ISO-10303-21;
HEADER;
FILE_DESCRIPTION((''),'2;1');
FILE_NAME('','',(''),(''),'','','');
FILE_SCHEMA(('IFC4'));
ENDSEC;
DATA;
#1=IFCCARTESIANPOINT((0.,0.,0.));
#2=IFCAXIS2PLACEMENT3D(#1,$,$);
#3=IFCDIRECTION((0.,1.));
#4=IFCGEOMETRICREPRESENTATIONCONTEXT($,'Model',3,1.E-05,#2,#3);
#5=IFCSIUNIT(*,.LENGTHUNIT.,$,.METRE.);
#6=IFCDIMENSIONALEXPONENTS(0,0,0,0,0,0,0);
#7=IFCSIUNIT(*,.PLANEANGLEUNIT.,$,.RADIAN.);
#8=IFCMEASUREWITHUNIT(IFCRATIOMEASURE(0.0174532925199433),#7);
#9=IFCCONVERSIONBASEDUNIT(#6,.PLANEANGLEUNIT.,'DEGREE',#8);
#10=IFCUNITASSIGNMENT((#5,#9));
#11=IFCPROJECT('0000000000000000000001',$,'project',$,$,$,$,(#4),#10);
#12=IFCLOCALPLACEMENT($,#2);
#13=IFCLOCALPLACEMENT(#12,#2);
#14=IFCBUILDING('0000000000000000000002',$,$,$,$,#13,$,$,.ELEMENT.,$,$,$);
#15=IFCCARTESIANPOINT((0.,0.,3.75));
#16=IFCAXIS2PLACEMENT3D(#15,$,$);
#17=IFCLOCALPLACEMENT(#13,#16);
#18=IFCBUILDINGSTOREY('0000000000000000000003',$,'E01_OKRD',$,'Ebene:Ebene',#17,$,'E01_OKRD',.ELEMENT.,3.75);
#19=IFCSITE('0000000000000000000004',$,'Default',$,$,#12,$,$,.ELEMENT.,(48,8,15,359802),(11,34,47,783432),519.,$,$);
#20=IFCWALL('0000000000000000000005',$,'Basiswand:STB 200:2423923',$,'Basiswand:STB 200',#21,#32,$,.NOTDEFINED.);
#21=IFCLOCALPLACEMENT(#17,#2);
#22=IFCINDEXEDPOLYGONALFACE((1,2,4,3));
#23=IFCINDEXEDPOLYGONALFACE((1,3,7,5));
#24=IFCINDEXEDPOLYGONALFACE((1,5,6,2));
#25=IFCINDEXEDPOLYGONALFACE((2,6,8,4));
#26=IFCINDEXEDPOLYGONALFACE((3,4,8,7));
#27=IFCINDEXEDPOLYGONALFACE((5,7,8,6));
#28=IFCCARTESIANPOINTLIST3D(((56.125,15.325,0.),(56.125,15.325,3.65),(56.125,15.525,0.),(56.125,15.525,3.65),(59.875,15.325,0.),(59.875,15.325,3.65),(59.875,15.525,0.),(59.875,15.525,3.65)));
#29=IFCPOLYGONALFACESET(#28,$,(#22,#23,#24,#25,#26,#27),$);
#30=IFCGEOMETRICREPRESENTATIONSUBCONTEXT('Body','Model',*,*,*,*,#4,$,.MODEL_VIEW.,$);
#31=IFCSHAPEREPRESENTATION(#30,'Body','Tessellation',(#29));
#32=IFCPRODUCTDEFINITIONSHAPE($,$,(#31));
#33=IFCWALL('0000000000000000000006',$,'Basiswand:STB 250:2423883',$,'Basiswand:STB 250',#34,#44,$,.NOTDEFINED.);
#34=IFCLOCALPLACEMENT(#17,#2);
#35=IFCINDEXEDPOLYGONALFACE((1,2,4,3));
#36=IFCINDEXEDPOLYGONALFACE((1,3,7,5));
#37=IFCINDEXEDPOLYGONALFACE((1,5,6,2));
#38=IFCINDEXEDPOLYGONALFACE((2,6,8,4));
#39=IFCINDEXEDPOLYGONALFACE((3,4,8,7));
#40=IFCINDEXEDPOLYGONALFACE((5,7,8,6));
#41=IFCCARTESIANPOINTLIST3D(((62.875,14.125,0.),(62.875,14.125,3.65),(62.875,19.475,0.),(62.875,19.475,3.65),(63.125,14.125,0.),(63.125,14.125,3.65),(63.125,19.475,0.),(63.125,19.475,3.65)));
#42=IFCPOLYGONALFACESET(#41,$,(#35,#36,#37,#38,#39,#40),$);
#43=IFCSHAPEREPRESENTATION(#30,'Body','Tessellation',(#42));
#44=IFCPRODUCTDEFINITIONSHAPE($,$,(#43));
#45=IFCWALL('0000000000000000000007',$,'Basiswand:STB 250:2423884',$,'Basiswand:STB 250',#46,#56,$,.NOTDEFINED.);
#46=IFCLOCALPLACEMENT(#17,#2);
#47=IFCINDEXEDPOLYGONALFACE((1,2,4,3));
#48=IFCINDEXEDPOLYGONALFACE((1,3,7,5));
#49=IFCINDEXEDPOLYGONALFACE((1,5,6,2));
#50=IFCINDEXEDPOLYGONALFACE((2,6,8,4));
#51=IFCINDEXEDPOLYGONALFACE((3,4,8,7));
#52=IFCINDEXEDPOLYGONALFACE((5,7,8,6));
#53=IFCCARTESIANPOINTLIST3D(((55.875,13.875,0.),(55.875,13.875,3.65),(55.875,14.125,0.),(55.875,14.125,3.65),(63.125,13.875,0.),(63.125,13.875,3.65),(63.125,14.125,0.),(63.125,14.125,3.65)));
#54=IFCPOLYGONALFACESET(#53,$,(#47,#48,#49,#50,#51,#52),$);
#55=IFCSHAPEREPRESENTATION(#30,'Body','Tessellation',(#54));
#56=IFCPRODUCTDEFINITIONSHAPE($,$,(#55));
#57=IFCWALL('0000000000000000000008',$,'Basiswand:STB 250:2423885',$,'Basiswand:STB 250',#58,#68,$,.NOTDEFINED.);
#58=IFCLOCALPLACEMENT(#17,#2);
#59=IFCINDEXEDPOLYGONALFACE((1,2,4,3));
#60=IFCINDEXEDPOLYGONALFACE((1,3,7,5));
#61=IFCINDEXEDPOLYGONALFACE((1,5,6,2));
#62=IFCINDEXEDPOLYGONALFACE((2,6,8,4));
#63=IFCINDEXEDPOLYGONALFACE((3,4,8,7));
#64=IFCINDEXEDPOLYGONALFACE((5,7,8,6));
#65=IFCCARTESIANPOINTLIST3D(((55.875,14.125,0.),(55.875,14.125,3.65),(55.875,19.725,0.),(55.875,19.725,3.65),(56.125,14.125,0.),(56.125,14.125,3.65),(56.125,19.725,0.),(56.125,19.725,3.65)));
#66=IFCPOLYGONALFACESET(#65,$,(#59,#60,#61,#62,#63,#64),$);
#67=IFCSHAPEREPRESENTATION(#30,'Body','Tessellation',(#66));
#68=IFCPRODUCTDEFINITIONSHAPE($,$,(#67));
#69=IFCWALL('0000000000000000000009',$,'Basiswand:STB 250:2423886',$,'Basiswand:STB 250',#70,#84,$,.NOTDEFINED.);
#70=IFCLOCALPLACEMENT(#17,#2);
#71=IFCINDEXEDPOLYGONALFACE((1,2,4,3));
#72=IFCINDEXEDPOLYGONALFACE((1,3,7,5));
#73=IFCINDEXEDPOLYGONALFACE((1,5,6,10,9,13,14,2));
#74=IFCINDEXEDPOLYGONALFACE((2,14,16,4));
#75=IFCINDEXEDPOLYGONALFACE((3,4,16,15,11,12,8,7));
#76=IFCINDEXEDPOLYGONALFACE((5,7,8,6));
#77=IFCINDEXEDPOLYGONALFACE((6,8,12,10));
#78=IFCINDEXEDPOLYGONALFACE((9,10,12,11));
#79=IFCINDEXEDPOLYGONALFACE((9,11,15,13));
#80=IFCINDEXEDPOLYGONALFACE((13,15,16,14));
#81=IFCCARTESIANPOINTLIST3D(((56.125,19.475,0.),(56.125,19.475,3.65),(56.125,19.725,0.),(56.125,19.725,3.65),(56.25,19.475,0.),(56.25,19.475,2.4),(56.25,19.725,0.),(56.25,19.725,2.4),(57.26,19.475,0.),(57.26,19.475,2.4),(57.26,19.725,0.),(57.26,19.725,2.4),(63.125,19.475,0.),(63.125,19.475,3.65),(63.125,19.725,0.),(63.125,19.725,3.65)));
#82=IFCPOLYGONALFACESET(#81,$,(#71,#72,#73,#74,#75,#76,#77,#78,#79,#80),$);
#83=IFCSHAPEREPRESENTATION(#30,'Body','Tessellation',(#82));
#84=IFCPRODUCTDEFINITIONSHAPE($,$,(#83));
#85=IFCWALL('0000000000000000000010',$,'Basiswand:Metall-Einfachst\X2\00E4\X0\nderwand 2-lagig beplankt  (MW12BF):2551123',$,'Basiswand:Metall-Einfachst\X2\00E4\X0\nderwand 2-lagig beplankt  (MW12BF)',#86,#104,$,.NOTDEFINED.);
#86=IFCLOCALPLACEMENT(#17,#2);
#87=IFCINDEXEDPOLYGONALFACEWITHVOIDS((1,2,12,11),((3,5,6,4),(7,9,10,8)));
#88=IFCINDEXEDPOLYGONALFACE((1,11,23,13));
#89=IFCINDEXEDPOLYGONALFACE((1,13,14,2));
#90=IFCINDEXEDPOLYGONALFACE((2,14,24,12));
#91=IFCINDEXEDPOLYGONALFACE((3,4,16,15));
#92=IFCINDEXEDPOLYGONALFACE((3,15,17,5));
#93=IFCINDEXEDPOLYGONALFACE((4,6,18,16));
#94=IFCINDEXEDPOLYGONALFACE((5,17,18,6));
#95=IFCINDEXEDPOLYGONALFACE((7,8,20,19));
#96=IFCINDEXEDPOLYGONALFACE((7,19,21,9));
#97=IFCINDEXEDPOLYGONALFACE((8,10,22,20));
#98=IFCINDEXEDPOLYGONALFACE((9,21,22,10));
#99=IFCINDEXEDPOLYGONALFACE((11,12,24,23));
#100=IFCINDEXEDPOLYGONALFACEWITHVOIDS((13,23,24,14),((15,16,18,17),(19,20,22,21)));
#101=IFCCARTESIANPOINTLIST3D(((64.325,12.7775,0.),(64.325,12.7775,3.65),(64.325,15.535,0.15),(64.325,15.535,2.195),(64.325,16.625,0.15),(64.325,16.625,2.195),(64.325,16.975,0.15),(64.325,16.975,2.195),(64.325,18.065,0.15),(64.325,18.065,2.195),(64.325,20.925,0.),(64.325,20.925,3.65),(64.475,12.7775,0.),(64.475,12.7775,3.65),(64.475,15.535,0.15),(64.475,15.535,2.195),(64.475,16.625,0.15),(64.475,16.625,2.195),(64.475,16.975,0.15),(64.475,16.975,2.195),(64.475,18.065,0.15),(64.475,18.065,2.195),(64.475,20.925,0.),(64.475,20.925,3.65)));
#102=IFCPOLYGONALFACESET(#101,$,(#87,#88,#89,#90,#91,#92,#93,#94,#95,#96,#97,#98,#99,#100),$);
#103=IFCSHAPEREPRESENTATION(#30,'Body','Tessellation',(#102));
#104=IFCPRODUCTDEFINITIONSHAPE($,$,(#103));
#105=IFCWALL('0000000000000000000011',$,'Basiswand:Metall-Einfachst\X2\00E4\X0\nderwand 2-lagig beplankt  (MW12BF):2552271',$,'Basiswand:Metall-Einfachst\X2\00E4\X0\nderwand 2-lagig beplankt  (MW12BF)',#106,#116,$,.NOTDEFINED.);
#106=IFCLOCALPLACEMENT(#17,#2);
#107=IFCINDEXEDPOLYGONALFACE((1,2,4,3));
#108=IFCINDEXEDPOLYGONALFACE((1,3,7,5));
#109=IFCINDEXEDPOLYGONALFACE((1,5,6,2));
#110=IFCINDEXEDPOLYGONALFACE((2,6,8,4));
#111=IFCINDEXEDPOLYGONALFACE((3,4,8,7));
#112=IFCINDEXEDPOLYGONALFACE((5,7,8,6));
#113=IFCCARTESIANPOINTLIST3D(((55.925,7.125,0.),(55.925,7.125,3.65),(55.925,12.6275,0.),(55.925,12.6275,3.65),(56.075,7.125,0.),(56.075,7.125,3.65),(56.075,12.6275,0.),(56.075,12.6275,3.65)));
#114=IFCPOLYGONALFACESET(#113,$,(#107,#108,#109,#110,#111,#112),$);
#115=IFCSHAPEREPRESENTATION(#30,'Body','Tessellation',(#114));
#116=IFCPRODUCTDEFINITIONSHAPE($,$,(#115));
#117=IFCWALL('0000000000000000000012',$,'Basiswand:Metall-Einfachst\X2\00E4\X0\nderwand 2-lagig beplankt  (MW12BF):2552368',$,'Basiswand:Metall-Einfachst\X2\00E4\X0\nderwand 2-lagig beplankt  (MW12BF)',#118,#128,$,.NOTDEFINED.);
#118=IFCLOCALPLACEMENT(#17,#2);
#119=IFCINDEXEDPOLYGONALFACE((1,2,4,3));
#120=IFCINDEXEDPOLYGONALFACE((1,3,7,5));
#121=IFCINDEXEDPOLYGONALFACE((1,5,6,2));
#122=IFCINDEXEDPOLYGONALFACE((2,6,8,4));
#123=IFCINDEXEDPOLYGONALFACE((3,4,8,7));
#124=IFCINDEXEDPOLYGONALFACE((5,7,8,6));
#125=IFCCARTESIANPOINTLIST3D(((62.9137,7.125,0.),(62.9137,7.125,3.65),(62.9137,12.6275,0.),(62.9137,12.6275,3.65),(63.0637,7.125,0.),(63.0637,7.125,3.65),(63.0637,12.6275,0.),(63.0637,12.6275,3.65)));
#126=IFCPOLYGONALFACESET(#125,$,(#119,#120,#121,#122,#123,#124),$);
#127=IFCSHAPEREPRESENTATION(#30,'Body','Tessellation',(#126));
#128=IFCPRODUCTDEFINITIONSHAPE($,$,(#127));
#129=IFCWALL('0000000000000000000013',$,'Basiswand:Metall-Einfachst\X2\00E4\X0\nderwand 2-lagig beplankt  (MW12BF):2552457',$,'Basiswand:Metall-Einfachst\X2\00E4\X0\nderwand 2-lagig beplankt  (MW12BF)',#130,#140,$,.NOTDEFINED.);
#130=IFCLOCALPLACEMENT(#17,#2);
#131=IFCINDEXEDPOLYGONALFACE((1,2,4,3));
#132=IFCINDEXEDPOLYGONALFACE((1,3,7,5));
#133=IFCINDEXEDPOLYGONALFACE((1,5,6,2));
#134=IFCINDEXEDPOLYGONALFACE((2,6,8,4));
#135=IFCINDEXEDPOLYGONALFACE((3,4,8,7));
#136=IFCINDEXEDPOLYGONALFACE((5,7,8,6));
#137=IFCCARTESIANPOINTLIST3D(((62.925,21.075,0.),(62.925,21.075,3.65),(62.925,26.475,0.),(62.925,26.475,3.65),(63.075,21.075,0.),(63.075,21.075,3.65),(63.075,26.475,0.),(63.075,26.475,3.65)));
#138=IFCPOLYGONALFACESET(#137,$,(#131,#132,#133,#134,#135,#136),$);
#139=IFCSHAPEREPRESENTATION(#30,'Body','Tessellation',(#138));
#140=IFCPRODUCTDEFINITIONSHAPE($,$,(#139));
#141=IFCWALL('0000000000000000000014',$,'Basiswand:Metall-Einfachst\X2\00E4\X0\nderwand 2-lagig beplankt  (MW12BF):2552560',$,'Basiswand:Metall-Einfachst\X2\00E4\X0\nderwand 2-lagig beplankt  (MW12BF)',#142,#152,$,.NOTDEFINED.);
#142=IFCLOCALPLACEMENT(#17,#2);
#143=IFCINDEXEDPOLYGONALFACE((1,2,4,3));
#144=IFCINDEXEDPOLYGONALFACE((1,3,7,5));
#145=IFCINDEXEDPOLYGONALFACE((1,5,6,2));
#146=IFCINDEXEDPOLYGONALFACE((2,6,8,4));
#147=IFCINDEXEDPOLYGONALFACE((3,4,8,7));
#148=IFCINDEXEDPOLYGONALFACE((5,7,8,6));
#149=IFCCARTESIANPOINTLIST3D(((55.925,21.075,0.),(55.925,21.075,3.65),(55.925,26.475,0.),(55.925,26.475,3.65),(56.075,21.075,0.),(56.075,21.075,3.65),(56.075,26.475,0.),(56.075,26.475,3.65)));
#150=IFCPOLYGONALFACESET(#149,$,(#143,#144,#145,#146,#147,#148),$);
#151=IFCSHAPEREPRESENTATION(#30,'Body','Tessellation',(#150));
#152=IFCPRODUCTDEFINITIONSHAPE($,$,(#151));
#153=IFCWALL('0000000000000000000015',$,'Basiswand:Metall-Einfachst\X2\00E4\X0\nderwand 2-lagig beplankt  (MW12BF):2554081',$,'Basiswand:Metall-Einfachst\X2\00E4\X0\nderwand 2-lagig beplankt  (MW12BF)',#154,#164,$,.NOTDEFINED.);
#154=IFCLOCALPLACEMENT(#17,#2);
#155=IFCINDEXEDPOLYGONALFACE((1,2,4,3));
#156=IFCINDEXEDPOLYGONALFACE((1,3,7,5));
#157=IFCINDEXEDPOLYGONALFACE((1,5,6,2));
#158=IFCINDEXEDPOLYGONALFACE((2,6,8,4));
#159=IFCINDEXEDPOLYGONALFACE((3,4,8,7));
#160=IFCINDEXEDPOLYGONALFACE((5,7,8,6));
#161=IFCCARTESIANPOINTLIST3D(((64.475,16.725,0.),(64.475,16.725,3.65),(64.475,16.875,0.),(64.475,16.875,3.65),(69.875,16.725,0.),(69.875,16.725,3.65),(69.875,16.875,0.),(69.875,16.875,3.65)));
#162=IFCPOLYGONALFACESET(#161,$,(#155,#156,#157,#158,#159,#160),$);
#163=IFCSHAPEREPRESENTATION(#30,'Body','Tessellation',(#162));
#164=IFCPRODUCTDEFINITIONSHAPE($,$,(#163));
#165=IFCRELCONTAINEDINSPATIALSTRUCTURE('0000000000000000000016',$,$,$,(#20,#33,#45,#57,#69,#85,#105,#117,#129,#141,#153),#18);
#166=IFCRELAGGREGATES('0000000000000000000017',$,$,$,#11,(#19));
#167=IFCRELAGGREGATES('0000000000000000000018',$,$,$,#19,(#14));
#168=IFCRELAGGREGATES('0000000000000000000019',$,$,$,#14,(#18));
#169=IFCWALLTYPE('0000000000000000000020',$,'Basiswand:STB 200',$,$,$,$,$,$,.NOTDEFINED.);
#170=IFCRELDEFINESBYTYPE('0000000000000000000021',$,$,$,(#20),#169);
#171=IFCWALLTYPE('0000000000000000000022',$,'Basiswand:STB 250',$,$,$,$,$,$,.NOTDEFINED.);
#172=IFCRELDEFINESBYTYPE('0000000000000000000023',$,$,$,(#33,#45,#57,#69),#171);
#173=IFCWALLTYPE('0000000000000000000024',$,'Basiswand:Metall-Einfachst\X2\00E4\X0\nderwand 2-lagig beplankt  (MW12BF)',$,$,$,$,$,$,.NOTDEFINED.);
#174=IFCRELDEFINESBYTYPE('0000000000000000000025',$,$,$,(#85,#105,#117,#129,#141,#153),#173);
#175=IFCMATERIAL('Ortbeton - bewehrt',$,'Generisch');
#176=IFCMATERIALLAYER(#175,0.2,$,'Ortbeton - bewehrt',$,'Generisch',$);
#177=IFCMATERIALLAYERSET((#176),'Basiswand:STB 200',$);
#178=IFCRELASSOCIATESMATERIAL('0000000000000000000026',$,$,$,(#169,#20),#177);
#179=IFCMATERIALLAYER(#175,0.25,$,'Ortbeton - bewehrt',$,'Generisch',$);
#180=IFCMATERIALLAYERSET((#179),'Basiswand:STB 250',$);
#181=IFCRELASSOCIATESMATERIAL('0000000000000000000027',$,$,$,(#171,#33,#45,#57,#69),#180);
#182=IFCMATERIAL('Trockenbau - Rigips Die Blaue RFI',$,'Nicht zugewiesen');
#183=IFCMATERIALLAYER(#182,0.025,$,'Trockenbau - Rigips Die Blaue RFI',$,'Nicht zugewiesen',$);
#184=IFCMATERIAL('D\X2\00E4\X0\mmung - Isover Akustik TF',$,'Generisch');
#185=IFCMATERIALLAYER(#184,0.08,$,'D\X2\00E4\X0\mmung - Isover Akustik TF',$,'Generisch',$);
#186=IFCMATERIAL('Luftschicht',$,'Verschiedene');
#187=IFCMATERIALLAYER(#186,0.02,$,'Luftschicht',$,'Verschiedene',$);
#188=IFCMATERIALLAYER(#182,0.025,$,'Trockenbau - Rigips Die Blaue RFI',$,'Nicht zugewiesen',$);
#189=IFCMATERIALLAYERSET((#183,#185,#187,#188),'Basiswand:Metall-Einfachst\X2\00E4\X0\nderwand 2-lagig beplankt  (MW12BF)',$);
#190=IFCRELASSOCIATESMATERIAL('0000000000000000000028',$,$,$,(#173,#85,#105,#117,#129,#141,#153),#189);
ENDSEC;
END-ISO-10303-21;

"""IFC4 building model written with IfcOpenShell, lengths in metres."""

from ifc_helpers import new_model, entity, si_unit, converted_unit, direction, frame, frame_2d, origin, place, context, subcontext, project, spatial, rectangle, extrude, material, layer, layer_set, layer_usage, type_object, element, save


model = new_model("IFC4")

# Units and contexts
model_context = context("Model", 3, precision=1e-05, world=origin(), true_north=direction((0.0, 1.0)))
body_context = subcontext(model_context, "Body", "Model", "MODEL_VIEW")
ifc_project = project(units=[si_unit("LENGTHUNIT", "METRE"), converted_unit("PLANEANGLEUNIT", "DEGREE", entity("IfcRatioMeasure", 0.0174532925199433), si_unit("PLANEANGLEUNIT", "RADIAN"), dimensions=[0, 0, 0, 0, 0, 0, 0])], contexts=[model_context])

# Site, building, storey
site_placement = place(None, frame((0.0, 0.0, 0.0)))
site = spatial("IfcSite", under=ifc_project, at=site_placement, Name="Default", CompositionType="ELEMENT", RefLatitude=(48, 8, 15, 359802), RefLongitude=(11, 34, 47, 783432), RefElevation=519.0)
building_placement = place(site_placement, origin())
building = spatial("IfcBuilding", under=site, at=building_placement, CompositionType="ELEMENT")
storey_placement = place(building_placement, frame((0.0, 0.0, 3.75)))
storey = spatial("IfcBuildingStorey", under=building, at=storey_placement, Name="E01_OKRD", ObjectType="Ebene:Ebene", LongName="E01_OKRD", CompositionType="ELEMENT", Elevation=3.75)

# Shared definitions
ifc_material_1 = material(Name="Ortbeton - bewehrt", Category="Generisch")

# Shared definitions
ifc_layer_1 = layer(ifc_material_1, 0.2, Name="Ortbeton - bewehrt", Category="Generisch")
ifc_layer_set_1 = layer_set([ifc_layer_1], Name="Basiswand:STB 200")
wall_type_1 = type_object("IfcWallType", Name="Basiswand:STB 200", PredefinedType="NOTDEFINED", material=ifc_layer_set_1)

# Walls
ifc_layer_usage_1 = layer_usage(ifc_layer_set_1, "AXIS2", "POSITIVE", -0.1)
wall_1_placement = place(storey_placement, frame((56.125, 15.425, 0.0)))
element("IfcWall", 1, at=wall_1_placement, inside=storey, type_object=wall_type_1, material=ifc_layer_usage_1, Name="Basiswand:STB 200:2423923", ObjectType="Basiswand:STB 200", PredefinedType="NOTDEFINED", context=body_context, shape_type="SweptSolid", body=[
    extrude(rectangle(XDim=3.75, YDim=0.2, at=frame_2d((1.875, 0.0), x_axis=(-1.0, 0.0))), origin(), (0.0, 0.0, 1.0), 3.65),
])
ifc_layer_2 = layer(ifc_material_1, 0.25, Name="Ortbeton - bewehrt", Category="Generisch")
ifc_layer_set_2 = layer_set([ifc_layer_2], Name="Basiswand:STB 250")
ifc_layer_usage_2 = layer_usage(ifc_layer_set_2, "AXIS2", "NEGATIVE", 0.125)
wall_type_2 = type_object("IfcWallType", Name="Basiswand:STB 250", PredefinedType="NOTDEFINED", material=ifc_layer_set_2)
wall_2_placement = place(storey_placement, frame((63.0, 14.125, 0.0), z_axis=(0.0, 0.0, 1.0), x_axis=(0.0, 1.0, 0.0)))
element("IfcWall", 2, at=wall_2_placement, inside=storey, type_object=wall_type_2, material=ifc_layer_usage_2, Name="Basiswand:STB 250:2423883", ObjectType="Basiswand:STB 250", PredefinedType="NOTDEFINED", context=body_context, shape_type="SweptSolid", body=[
    extrude(rectangle(XDim=5.35, YDim=0.25, at=frame_2d((2.675, 0.0), x_axis=(-1.0, 0.0))), origin(), (0.0, 0.0, 1.0), 3.65),
])
ifc_layer_usage_3 = layer_usage(ifc_layer_set_2, "AXIS2", "NEGATIVE", 0.125)
wall_3_placement = place(storey_placement, frame((63.125, 14.0, 0.0), z_axis=(0.0, 0.0, 1.0), x_axis=(-1.0, 0.0, 0.0)))
element("IfcWall", 3, at=wall_3_placement, inside=storey, type_object=wall_type_2, material=ifc_layer_usage_3, Name="Basiswand:STB 250:2423884", ObjectType="Basiswand:STB 250", PredefinedType="NOTDEFINED", context=body_context, shape_type="SweptSolid", body=[
    extrude(rectangle(XDim=7.25, YDim=0.25, at=frame_2d((3.625, 0.0), x_axis=(-1.0, 0.0))), origin(), (0.0, 0.0, 1.0), 3.65),
])
ifc_layer_usage_4 = layer_usage(ifc_layer_set_2, "AXIS2", "NEGATIVE", 0.125)
wall_4_placement = place(storey_placement, frame((56.0, 14.125, 0.0), z_axis=(0.0, 0.0, 1.0), x_axis=(0.0, 1.0, 0.0)))
element("IfcWall", 4, at=wall_4_placement, inside=storey, type_object=wall_type_2, material=ifc_layer_usage_4, Name="Basiswand:STB 250:2423885", ObjectType="Basiswand:STB 250", PredefinedType="NOTDEFINED", context=body_context, shape_type="SweptSolid", body=[
    extrude(rectangle(XDim=5.6, YDim=0.25, at=frame_2d((2.8, 0.0), x_axis=(-1.0, 0.0))), origin(), (0.0, 0.0, 1.0), 3.65),
])

# Wall, opening
ifc_layer_usage_5 = layer_usage(ifc_layer_set_2, "AXIS2", "NEGATIVE", 0.125)
wall_5_placement = place(storey_placement, frame((56.125, 19.6, 0.0)))
wall_5 = element("IfcWall", 5, at=wall_5_placement, inside=storey, type_object=wall_type_2, material=ifc_layer_usage_5, Name="Basiswand:STB 250:2423886", ObjectType="Basiswand:STB 250", PredefinedType="NOTDEFINED", context=body_context, shape_type="SweptSolid", body=[
    extrude(rectangle(XDim=7.0, YDim=0.25, at=frame_2d((3.5, 0.0), x_axis=(-1.0, 0.0))), origin(), (0.0, 0.0, 1.0), 3.65),
])
opening_1_placement = place(wall_5_placement, frame((0.125, -0.125, 0.0)))
element("IfcOpeningElement", 6, at=opening_1_placement, cuts=wall_5, ObjectType="Opening", PredefinedType="OPENING", context=body_context, shape_type="SweptSolid", body=[
    extrude(rectangle(XDim=2.4, YDim=1.01, at=frame_2d((0.0, 0.0), x_axis=(0.0, 1.0))), frame((0.505, 0.0, 1.2), z_axis=(0.0, 1.0, 0.0), x_axis=(1.0, 0.0, 0.0)), (0.0, 0.0, 1.0), 0.25),
    extrude(rectangle(XDim=2.27, YDim=0.95, at=frame_2d((0.0, 0.0), x_axis=(1.0, 0.0))), frame((0.505, 0.295, 1.235), z_axis=(0.0, 1.0, 0.0), x_axis=(0.0, 0.0, -1.0)), (0.0, 0.0, 1.0), 0.255),
])

# Wall, openings
ifc_material_2 = material(Name="Trockenbau - Rigips Die Blaue RFI", Category="Nicht zugewiesen")
ifc_layer_3 = layer(ifc_material_2, 0.025, Name="Trockenbau - Rigips Die Blaue RFI", Category="Nicht zugewiesen")
ifc_material_3 = material(Name="Dämmung - Isover Akustik TF", Category="Generisch")
ifc_layer_4 = layer(ifc_material_3, 0.08, Name="Dämmung - Isover Akustik TF", Category="Generisch")
ifc_material_4 = material(Name="Luftschicht", Category="Verschiedene")
ifc_layer_5 = layer(ifc_material_4, 0.02, Name="Luftschicht", Category="Verschiedene")
ifc_layer_6 = layer(ifc_material_2, 0.025, Name="Trockenbau - Rigips Die Blaue RFI", Category="Nicht zugewiesen")
ifc_layer_set_3 = layer_set([ifc_layer_3, ifc_layer_4, ifc_layer_5, ifc_layer_6], Name="Basiswand:Metall-Einfachständerwand 2-lagig beplankt  (MW12BF)")
ifc_layer_usage_6 = layer_usage(ifc_layer_set_3, "AXIS2", "NEGATIVE", 0.075)
wall_type_3 = type_object("IfcWallType", Name="Basiswand:Metall-Einfachständerwand 2-lagig beplankt  (MW12BF)", PredefinedType="NOTDEFINED", material=ifc_layer_set_3)
wall_6_placement = place(storey_placement, frame((64.4, 20.925, 0.0), z_axis=(0.0, 0.0, 1.0), x_axis=(0.0, -1.0, 0.0)))
wall_6 = element("IfcWall", 7, at=wall_6_placement, inside=storey, type_object=wall_type_3, material=ifc_layer_usage_6, Name="Basiswand:Metall-Einfachständerwand 2-lagig beplankt  (MW12BF):2551123", ObjectType="Basiswand:Metall-Einfachständerwand 2-lagig beplankt  (MW12BF)", PredefinedType="NOTDEFINED", context=body_context, shape_type="SweptSolid", body=[
    extrude(rectangle(XDim=8.1475, YDim=0.15, at=frame_2d((4.0738, 0.0), x_axis=(-1.0, 0.0))), origin(), (0.0, 0.0, 1.0), 3.65),
])
opening_2_placement = place(wall_6_placement, frame((2.86, -0.075, 0.15)))
element("IfcOpeningElement", 8, at=opening_2_placement, cuts=wall_6, ObjectType="Opening", PredefinedType="OPENING", context=body_context, shape_type="SweptSolid", body=[
    extrude(rectangle(XDim=2.045, YDim=1.09, at=frame_2d((1.0225, 0.545), x_axis=(-1.0, 0.0))), frame((0.0, 0.0, 0.0), z_axis=(0.0, 1.0, 0.0), x_axis=(0.0, 0.0, 1.0)), (0.0, 0.0, 1.0), 0.15),
])
opening_3_placement = place(wall_6_placement, frame((4.3, -0.075, 0.15)))
element("IfcOpeningElement", 9, at=opening_3_placement, cuts=wall_6, ObjectType="Opening", PredefinedType="OPENING", context=body_context, shape_type="SweptSolid", body=[
    extrude(rectangle(XDim=2.045, YDim=1.09, at=frame_2d((1.0225, 0.545), x_axis=(-1.0, 0.0))), frame((0.0, 0.0, 0.0), z_axis=(0.0, 1.0, 0.0), x_axis=(0.0, 0.0, 1.0)), (0.0, 0.0, 1.0), 0.15),
])

# Walls
ifc_layer_usage_7 = layer_usage(ifc_layer_set_3, "AXIS2", "NEGATIVE", 0.075)
wall_7_placement = place(storey_placement, frame((56.0, 12.6275, 0.0), z_axis=(0.0, 0.0, 1.0), x_axis=(0.0, -1.0, 0.0)))
element("IfcWall", 10, at=wall_7_placement, inside=storey, type_object=wall_type_3, material=ifc_layer_usage_7, Name="Basiswand:Metall-Einfachständerwand 2-lagig beplankt  (MW12BF):2552271", ObjectType="Basiswand:Metall-Einfachständerwand 2-lagig beplankt  (MW12BF)", PredefinedType="NOTDEFINED", context=body_context, shape_type="SweptSolid", body=[
    extrude(rectangle(XDim=5.5025, YDim=0.15, at=frame_2d((2.7513, 0.0), x_axis=(-1.0, 0.0))), origin(), (0.0, 0.0, 1.0), 3.65),
])
ifc_layer_usage_8 = layer_usage(ifc_layer_set_3, "AXIS2", "NEGATIVE", 0.075)
wall_8_placement = place(storey_placement, frame((62.9887, 12.6275, 0.0), z_axis=(0.0, 0.0, 1.0), x_axis=(0.0, -1.0, 0.0)))
element("IfcWall", 11, at=wall_8_placement, inside=storey, type_object=wall_type_3, material=ifc_layer_usage_8, Name="Basiswand:Metall-Einfachständerwand 2-lagig beplankt  (MW12BF):2552368", ObjectType="Basiswand:Metall-Einfachständerwand 2-lagig beplankt  (MW12BF)", PredefinedType="NOTDEFINED", context=body_context, shape_type="SweptSolid", body=[
    extrude(rectangle(XDim=5.5025, YDim=0.15, at=frame_2d((2.7513, 0.0), x_axis=(-1.0, 0.0))), origin(), (0.0, 0.0, 1.0), 3.65),
])
ifc_layer_usage_9 = layer_usage(ifc_layer_set_3, "AXIS2", "NEGATIVE", 0.075)
wall_9_placement = place(storey_placement, frame((63.0, 21.075, 0.0), z_axis=(0.0, 0.0, 1.0), x_axis=(0.0, 1.0, 0.0)))
element("IfcWall", 12, at=wall_9_placement, inside=storey, type_object=wall_type_3, material=ifc_layer_usage_9, Name="Basiswand:Metall-Einfachständerwand 2-lagig beplankt  (MW12BF):2552457", ObjectType="Basiswand:Metall-Einfachständerwand 2-lagig beplankt  (MW12BF)", PredefinedType="NOTDEFINED", context=body_context, shape_type="SweptSolid", body=[
    extrude(rectangle(XDim=5.4, YDim=0.15, at=frame_2d((2.7, 0.0), x_axis=(-1.0, 0.0))), origin(), (0.0, 0.0, 1.0), 3.65),
])
ifc_layer_usage_10 = layer_usage(ifc_layer_set_3, "AXIS2", "NEGATIVE", 0.075)
wall_10_placement = place(storey_placement, frame((56.0, 21.075, 0.0), z_axis=(0.0, 0.0, 1.0), x_axis=(0.0, 1.0, 0.0)))
element("IfcWall", 13, at=wall_10_placement, inside=storey, type_object=wall_type_3, material=ifc_layer_usage_10, Name="Basiswand:Metall-Einfachständerwand 2-lagig beplankt  (MW12BF):2552560", ObjectType="Basiswand:Metall-Einfachständerwand 2-lagig beplankt  (MW12BF)", PredefinedType="NOTDEFINED", context=body_context, shape_type="SweptSolid", body=[
    extrude(rectangle(XDim=5.4, YDim=0.15, at=frame_2d((2.7, 0.0), x_axis=(-1.0, 0.0))), origin(), (0.0, 0.0, 1.0), 3.65),
])
ifc_layer_usage_11 = layer_usage(ifc_layer_set_3, "AXIS2", "NEGATIVE", 0.075)
wall_11_placement = place(storey_placement, frame((69.875, 16.8, 0.0), z_axis=(0.0, 0.0, 1.0), x_axis=(-1.0, 0.0, 0.0)))
element("IfcWall", 14, at=wall_11_placement, inside=storey, type_object=wall_type_3, material=ifc_layer_usage_11, Name="Basiswand:Metall-Einfachständerwand 2-lagig beplankt  (MW12BF):2554081", ObjectType="Basiswand:Metall-Einfachständerwand 2-lagig beplankt  (MW12BF)", PredefinedType="NOTDEFINED", context=body_context, shape_type="SweptSolid", body=[
    extrude(rectangle(XDim=5.4, YDim=0.15, at=frame_2d((2.7, 0.0), x_axis=(-1.0, 0.0))), origin(), (0.0, 0.0, 1.0), 3.65),
])

save(model, "model.ifc")
